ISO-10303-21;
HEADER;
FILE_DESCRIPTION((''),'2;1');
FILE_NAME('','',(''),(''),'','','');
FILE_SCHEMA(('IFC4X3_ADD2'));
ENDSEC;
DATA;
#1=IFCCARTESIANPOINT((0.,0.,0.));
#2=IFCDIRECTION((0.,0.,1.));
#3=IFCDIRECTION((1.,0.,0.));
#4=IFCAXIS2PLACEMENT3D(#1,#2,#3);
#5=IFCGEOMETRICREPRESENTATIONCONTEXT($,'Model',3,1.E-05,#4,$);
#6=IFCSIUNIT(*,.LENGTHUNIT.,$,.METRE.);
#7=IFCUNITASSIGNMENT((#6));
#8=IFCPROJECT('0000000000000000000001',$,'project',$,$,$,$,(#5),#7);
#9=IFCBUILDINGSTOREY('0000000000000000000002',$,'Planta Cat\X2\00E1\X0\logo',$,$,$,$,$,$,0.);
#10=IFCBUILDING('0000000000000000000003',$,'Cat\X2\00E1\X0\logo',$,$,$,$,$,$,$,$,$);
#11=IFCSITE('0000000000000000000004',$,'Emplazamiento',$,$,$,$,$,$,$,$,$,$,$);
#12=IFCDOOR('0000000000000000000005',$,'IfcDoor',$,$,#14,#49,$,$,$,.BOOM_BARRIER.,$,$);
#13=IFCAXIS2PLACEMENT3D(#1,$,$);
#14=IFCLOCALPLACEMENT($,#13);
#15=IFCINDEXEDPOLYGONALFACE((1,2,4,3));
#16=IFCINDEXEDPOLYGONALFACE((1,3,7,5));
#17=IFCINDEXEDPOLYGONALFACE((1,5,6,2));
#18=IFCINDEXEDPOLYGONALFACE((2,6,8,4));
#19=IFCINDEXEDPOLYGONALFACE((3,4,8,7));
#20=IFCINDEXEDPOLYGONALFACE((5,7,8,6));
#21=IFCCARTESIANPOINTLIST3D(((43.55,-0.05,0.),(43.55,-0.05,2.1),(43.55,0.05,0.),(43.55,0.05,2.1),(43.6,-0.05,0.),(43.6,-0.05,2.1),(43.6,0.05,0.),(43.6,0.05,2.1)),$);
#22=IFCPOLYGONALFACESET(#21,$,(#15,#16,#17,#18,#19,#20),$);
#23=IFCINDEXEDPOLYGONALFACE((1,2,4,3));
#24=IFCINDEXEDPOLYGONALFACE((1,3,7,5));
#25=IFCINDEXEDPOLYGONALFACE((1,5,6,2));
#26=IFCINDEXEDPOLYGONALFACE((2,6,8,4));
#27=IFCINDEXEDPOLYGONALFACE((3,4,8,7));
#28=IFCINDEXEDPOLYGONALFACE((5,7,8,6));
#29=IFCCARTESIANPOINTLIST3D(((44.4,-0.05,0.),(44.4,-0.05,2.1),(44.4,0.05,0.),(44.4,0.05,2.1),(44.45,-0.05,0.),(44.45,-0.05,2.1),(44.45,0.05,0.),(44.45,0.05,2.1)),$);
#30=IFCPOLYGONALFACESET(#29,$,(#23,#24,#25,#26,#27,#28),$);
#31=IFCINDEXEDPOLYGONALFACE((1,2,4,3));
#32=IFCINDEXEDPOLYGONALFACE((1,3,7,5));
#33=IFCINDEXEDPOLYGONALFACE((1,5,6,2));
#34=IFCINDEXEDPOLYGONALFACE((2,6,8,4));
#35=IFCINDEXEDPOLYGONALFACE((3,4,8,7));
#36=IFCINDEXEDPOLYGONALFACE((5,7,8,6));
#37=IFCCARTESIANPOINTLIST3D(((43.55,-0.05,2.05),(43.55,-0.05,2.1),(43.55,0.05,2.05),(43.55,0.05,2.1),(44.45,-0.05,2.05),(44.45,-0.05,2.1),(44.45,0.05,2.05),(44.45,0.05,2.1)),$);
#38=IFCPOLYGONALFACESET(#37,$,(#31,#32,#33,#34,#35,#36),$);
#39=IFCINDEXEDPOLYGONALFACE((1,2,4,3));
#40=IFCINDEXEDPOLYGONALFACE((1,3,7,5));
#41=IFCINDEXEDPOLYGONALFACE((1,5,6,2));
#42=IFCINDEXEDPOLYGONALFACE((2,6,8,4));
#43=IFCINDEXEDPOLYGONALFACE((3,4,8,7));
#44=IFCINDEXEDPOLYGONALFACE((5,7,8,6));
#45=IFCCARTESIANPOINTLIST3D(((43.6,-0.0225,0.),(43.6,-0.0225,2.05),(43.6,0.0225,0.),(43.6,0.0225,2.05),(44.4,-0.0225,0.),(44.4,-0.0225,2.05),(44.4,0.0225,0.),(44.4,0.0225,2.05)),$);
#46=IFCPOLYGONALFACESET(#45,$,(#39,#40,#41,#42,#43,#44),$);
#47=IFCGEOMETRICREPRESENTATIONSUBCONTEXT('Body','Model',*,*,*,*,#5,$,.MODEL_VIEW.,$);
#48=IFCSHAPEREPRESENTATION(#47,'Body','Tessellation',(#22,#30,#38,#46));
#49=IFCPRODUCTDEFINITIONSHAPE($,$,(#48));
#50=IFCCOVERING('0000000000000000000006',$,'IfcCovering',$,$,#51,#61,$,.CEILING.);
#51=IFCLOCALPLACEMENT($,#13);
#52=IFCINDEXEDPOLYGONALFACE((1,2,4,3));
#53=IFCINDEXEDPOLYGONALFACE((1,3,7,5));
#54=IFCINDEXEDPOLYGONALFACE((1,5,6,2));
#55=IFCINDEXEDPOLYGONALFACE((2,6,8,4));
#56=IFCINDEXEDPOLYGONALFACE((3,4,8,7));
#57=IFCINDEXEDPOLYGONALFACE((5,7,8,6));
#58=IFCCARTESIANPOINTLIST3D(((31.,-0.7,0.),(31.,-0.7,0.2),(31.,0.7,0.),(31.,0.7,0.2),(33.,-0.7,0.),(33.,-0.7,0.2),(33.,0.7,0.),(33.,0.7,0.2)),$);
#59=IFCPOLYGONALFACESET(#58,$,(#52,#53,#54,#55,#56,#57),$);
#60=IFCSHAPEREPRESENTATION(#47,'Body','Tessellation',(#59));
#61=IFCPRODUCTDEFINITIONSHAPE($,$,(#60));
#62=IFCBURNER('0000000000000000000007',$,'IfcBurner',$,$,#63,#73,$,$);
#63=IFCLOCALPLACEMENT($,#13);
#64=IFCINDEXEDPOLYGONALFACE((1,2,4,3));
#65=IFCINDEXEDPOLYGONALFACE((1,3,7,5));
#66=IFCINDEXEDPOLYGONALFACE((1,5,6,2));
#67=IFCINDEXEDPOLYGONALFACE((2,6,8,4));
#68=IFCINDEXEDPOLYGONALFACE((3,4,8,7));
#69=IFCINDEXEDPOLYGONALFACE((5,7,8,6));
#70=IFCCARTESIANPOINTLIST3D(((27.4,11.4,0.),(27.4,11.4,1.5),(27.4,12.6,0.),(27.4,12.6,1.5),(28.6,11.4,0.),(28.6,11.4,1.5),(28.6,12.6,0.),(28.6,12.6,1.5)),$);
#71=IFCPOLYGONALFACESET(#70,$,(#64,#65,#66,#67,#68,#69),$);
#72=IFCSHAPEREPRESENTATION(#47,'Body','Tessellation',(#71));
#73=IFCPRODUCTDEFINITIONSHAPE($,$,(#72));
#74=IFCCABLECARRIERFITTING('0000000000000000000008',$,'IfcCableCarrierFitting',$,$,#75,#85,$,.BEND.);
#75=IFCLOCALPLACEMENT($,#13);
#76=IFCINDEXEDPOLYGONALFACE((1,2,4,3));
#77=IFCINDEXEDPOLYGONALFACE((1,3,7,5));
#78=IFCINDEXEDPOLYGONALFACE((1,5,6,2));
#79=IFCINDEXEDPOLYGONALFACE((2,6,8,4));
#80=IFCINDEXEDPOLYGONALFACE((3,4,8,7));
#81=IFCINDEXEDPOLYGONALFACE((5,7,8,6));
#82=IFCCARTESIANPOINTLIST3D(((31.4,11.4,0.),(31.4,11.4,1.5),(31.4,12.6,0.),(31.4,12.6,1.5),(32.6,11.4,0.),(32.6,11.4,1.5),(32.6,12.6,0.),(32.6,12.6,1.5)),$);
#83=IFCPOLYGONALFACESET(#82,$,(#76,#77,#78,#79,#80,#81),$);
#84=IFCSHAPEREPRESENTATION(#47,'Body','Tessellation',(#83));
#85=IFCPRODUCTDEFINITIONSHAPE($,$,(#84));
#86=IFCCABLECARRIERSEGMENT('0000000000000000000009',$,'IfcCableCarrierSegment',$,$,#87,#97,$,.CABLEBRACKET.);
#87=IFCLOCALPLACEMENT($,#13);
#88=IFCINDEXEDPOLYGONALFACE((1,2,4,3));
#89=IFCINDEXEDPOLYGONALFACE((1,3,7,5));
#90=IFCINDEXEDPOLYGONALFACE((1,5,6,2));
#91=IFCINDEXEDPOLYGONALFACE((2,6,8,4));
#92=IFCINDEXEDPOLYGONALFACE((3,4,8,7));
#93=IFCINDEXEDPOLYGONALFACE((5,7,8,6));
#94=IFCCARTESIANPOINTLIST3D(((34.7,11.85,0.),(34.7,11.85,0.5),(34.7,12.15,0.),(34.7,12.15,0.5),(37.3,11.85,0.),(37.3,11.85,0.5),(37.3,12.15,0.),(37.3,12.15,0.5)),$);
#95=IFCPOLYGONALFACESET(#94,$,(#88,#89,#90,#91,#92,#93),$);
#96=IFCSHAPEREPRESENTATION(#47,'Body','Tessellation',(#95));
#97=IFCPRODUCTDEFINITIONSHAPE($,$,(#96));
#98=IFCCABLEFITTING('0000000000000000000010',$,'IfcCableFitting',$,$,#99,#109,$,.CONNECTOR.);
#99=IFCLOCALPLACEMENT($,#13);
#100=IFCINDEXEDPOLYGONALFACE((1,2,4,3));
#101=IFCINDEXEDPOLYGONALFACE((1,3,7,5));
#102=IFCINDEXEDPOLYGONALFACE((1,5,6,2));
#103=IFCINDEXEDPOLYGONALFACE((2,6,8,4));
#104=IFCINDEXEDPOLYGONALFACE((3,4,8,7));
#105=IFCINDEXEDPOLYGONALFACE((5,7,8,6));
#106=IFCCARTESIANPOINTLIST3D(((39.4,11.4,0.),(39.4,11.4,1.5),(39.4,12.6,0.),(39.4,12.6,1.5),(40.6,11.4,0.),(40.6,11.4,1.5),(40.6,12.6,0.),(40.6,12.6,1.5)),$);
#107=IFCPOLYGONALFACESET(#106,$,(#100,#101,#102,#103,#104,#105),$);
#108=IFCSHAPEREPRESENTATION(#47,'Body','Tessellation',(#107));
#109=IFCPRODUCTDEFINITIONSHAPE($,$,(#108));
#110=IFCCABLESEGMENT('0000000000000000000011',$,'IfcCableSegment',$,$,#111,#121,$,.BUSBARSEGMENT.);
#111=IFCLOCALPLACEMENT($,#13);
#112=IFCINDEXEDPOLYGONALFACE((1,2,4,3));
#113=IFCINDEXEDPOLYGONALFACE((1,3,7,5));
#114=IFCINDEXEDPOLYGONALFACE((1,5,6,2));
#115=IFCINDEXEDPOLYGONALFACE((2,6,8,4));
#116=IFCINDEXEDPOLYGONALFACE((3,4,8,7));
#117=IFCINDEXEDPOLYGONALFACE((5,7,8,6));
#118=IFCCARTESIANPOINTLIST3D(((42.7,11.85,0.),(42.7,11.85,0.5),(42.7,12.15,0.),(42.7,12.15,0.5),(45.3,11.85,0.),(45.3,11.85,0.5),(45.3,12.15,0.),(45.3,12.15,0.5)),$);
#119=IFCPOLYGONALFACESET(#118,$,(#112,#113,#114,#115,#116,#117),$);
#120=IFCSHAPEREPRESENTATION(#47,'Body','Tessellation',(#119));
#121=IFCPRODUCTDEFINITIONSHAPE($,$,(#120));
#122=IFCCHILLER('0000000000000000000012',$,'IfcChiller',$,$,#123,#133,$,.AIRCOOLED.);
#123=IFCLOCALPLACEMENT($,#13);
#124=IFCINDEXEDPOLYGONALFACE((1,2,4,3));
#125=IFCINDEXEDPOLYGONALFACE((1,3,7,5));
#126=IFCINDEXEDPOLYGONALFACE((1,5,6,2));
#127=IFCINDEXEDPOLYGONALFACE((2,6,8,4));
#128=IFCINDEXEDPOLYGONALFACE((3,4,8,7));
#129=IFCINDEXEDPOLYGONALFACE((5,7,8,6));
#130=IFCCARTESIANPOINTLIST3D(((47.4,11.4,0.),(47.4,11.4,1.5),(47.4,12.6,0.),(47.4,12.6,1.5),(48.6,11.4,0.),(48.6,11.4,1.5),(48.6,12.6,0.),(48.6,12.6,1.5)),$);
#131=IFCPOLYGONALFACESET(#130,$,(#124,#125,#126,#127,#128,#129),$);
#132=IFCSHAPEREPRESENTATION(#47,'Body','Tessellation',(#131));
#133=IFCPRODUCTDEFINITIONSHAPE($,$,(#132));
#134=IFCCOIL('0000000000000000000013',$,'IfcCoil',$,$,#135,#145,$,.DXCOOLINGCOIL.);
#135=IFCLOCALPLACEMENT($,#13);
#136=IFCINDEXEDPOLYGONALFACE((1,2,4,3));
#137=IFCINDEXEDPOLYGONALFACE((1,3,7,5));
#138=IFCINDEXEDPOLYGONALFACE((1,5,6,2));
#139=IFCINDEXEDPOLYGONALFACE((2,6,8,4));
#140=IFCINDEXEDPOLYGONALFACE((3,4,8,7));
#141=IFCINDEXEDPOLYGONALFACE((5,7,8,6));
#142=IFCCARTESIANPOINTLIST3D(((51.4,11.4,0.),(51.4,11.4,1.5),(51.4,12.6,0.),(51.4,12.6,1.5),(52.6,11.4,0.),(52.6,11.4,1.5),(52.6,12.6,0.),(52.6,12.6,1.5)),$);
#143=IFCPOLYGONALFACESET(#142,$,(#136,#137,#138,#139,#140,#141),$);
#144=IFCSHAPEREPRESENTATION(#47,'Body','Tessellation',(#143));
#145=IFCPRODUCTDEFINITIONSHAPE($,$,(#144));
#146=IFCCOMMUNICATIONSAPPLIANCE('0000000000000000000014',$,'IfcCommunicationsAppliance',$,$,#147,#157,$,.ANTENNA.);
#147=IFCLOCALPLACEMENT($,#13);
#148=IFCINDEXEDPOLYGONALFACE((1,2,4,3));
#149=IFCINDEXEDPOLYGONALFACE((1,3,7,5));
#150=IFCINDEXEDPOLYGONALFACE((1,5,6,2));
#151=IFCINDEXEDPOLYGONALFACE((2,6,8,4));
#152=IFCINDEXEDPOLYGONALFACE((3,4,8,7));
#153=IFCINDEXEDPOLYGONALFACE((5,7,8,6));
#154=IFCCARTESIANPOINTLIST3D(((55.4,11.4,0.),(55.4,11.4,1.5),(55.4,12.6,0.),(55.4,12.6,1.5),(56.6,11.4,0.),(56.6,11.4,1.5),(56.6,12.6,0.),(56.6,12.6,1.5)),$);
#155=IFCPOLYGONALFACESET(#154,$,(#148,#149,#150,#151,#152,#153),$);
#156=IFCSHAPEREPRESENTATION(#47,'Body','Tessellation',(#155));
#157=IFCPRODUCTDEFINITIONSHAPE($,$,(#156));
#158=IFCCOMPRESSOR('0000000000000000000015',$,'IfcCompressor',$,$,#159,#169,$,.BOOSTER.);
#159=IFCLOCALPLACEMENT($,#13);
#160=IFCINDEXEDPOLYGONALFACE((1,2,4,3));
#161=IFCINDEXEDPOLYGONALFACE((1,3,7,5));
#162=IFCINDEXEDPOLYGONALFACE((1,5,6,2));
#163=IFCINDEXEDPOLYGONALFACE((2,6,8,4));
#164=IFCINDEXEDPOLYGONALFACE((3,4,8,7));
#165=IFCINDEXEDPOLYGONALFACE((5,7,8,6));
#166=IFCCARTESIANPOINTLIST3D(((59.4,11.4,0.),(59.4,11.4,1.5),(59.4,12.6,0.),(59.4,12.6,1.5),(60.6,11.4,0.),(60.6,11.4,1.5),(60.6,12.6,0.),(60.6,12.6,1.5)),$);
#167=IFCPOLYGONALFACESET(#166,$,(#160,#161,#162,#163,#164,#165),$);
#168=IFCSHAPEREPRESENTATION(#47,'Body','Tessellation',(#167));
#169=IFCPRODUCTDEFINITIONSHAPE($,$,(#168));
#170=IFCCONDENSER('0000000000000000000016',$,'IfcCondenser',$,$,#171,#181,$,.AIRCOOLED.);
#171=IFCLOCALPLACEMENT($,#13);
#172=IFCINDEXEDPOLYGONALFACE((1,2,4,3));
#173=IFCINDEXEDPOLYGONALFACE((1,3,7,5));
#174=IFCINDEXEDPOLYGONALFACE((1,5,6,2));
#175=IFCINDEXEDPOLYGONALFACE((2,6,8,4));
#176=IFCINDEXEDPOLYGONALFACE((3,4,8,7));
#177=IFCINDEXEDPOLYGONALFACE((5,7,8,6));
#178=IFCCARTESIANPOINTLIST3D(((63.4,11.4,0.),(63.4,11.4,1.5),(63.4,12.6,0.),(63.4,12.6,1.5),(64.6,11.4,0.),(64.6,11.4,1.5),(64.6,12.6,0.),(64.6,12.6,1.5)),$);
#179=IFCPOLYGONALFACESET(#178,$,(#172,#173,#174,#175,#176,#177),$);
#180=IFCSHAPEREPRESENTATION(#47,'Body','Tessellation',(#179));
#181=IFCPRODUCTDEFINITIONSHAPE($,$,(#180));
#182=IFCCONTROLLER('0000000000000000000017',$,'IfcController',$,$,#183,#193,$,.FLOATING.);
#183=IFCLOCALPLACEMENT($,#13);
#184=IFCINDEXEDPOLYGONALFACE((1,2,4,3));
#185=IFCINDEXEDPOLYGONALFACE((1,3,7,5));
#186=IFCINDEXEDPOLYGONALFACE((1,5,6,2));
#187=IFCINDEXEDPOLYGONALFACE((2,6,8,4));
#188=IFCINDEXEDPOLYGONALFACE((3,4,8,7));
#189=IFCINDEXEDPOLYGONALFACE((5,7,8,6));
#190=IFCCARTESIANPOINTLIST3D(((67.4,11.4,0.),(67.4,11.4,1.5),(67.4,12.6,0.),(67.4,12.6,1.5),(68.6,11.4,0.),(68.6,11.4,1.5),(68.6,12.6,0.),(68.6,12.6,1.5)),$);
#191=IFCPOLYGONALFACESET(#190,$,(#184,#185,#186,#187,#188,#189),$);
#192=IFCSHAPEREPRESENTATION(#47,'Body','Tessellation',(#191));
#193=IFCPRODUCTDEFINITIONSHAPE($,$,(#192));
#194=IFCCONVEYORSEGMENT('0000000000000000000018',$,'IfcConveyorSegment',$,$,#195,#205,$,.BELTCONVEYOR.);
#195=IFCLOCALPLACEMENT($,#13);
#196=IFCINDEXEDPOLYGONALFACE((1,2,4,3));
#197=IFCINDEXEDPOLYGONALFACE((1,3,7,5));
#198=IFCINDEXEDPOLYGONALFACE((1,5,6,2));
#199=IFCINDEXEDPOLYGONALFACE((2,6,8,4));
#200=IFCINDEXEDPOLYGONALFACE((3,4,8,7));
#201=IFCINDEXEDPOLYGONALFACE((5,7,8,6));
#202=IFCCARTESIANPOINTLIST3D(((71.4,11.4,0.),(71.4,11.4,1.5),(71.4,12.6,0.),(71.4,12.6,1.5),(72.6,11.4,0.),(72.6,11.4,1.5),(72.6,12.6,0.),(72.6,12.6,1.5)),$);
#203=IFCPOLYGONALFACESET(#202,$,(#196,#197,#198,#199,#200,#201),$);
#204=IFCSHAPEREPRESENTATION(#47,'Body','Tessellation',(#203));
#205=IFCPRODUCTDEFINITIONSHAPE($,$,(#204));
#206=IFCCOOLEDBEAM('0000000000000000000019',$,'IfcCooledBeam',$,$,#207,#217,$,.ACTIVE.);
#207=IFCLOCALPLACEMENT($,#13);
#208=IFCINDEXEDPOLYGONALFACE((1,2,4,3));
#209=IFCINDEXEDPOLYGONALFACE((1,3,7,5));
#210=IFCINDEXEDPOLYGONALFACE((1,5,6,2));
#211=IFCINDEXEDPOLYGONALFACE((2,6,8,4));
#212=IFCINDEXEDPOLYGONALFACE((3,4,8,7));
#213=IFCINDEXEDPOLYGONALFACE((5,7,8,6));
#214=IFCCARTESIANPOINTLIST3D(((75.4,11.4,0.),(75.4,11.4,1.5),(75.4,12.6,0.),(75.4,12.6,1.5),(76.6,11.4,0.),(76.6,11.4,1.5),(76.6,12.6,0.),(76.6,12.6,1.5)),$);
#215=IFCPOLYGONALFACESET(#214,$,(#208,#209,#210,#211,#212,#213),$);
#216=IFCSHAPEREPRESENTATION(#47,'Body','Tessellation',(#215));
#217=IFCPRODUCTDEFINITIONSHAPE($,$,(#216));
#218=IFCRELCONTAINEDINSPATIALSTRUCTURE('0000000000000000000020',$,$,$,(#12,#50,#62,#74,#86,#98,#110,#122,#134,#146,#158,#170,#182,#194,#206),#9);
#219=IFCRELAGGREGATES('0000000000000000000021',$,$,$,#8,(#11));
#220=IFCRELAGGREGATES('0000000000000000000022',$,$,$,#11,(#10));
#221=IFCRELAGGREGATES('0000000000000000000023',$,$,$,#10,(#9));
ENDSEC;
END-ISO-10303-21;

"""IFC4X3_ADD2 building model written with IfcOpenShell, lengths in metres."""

from ifc_helpers import new_model, si_unit, frame, origin, origin_with_axes, origin_2d, place, context, subcontext, project, spatial, rectangle, extrude, element, save


model = new_model("IFC4X3_ADD2")

# Units and contexts
model_context = context("Model", 3, precision=1e-05, world=origin_with_axes())
body_context = subcontext(model_context, "Body", "Model", "MODEL_VIEW")
ifc_project = project(units=[si_unit("LENGTHUNIT", "METRE")], contexts=[model_context])

# Site, building, storey
site = spatial("IfcSite", under=ifc_project, Name="Emplazamiento")
building = spatial("IfcBuilding", under=site, Name="Catálogo")
storey = spatial("IfcBuildingStorey", under=building, Name="Planta Catálogo", Elevation=0.0)

# Door
door_placement = place(None, frame((44.0, 0.0, 0.0), z_axis=(0.0, 0.0, 1.0), x_axis=(1.0, 0.0, 0.0)))
element("IfcDoor", 1, at=door_placement, inside=storey, Name="IfcDoor", PredefinedType="BOOM_BARRIER", context=body_context, shape_type="SweptSolid", body=[
    extrude(rectangle(XDim=0.05, YDim=0.1, at=origin_2d()), frame((-0.425, 0.0, 0.0)), (0.0, 0.0, 1.0), 2.1),
    extrude(rectangle(XDim=0.05, YDim=0.1, at=origin_2d()), frame((0.425, 0.0, 0.0)), (0.0, 0.0, 1.0), 2.1),
    extrude(rectangle(XDim=0.9, YDim=0.1, at=origin_2d()), frame((0.0, 0.0, 2.05)), (0.0, 0.0, 1.0), 0.05),
    extrude(rectangle(XDim=0.8, YDim=0.045, at=origin_2d()), origin(), (0.0, 0.0, 1.0), 2.05),
])

# Covering
covering_placement = place(None, frame((32.0, 0.0, 0.0), z_axis=(0.0, 0.0, 1.0), x_axis=(1.0, 0.0, 0.0)))
element("IfcCovering", 2, at=covering_placement, inside=storey, Name="IfcCovering", PredefinedType="CEILING", context=body_context, shape_type="SweptSolid", body=[
    extrude(rectangle(XDim=2.0, YDim=1.4, at=origin_2d()), origin(), (0.0, 0.0, 1.0), 0.2),
])

# Burner
burner_placement = place(None, frame((28.0, 12.0, 0.0), z_axis=(0.0, 0.0, 1.0), x_axis=(1.0, 0.0, 0.0)))
element("IfcBurner", 3, at=burner_placement, inside=storey, Name="IfcBurner", context=body_context, shape_type="SweptSolid", body=[
    extrude(rectangle(XDim=1.2, YDim=1.2, at=origin_2d()), origin(), (0.0, 0.0, 1.0), 1.5),
])

# Cable carrier fitting
cable_carrier_fitting_placement = place(None, frame((32.0, 12.0, 0.0), z_axis=(0.0, 0.0, 1.0), x_axis=(1.0, 0.0, 0.0)))
element("IfcCableCarrierFitting", 4, at=cable_carrier_fitting_placement, inside=storey, Name="IfcCableCarrierFitting", PredefinedType="BEND", context=body_context, shape_type="SweptSolid", body=[
    extrude(rectangle(XDim=1.2, YDim=1.2, at=origin_2d()), origin(), (0.0, 0.0, 1.0), 1.5),
])

# Cable carrier segment
cable_carrier_segment_placement = place(None, frame((36.0, 12.0, 0.0), z_axis=(0.0, 0.0, 1.0), x_axis=(1.0, 0.0, 0.0)))
element("IfcCableCarrierSegment", 5, at=cable_carrier_segment_placement, inside=storey, Name="IfcCableCarrierSegment", PredefinedType="CABLEBRACKET", context=body_context, shape_type="SweptSolid", body=[
    extrude(rectangle(XDim=2.6, YDim=0.3, at=origin_2d()), origin(), (0.0, 0.0, 1.0), 0.5),
])

# Cable fitting
cable_fitting_placement = place(None, frame((40.0, 12.0, 0.0), z_axis=(0.0, 0.0, 1.0), x_axis=(1.0, 0.0, 0.0)))
element("IfcCableFitting", 6, at=cable_fitting_placement, inside=storey, Name="IfcCableFitting", PredefinedType="CONNECTOR", context=body_context, shape_type="SweptSolid", body=[
    extrude(rectangle(XDim=1.2, YDim=1.2, at=origin_2d()), origin(), (0.0, 0.0, 1.0), 1.5),
])

# Cable segment
cable_segment_placement = place(None, frame((44.0, 12.0, 0.0), z_axis=(0.0, 0.0, 1.0), x_axis=(1.0, 0.0, 0.0)))
element("IfcCableSegment", 7, at=cable_segment_placement, inside=storey, Name="IfcCableSegment", PredefinedType="BUSBARSEGMENT", context=body_context, shape_type="SweptSolid", body=[
    extrude(rectangle(XDim=2.6, YDim=0.3, at=origin_2d()), origin(), (0.0, 0.0, 1.0), 0.5),
])

# Chiller
chiller_placement = place(None, frame((48.0, 12.0, 0.0), z_axis=(0.0, 0.0, 1.0), x_axis=(1.0, 0.0, 0.0)))
element("IfcChiller", 8, at=chiller_placement, inside=storey, Name="IfcChiller", PredefinedType="AIRCOOLED", context=body_context, shape_type="SweptSolid", body=[
    extrude(rectangle(XDim=1.2, YDim=1.2, at=origin_2d()), origin(), (0.0, 0.0, 1.0), 1.5),
])

# Coil
coil_placement = place(None, frame((52.0, 12.0, 0.0), z_axis=(0.0, 0.0, 1.0), x_axis=(1.0, 0.0, 0.0)))
element("IfcCoil", 9, at=coil_placement, inside=storey, Name="IfcCoil", PredefinedType="DXCOOLINGCOIL", context=body_context, shape_type="SweptSolid", body=[
    extrude(rectangle(XDim=1.2, YDim=1.2, at=origin_2d()), origin(), (0.0, 0.0, 1.0), 1.5),
])

# Communications appliance
communications_appliance_placement = place(None, frame((56.0, 12.0, 0.0), z_axis=(0.0, 0.0, 1.0), x_axis=(1.0, 0.0, 0.0)))
element("IfcCommunicationsAppliance", 10, at=communications_appliance_placement, inside=storey, Name="IfcCommunicationsAppliance", PredefinedType="ANTENNA", context=body_context, shape_type="SweptSolid", body=[
    extrude(rectangle(XDim=1.2, YDim=1.2, at=origin_2d()), origin(), (0.0, 0.0, 1.0), 1.5),
])

# Compressor
compressor_placement = place(None, frame((60.0, 12.0, 0.0), z_axis=(0.0, 0.0, 1.0), x_axis=(1.0, 0.0, 0.0)))
element("IfcCompressor", 11, at=compressor_placement, inside=storey, Name="IfcCompressor", PredefinedType="BOOSTER", context=body_context, shape_type="SweptSolid", body=[
    extrude(rectangle(XDim=1.2, YDim=1.2, at=origin_2d()), origin(), (0.0, 0.0, 1.0), 1.5),
])

# Condenser
condenser_placement = place(None, frame((64.0, 12.0, 0.0), z_axis=(0.0, 0.0, 1.0), x_axis=(1.0, 0.0, 0.0)))
element("IfcCondenser", 12, at=condenser_placement, inside=storey, Name="IfcCondenser", PredefinedType="AIRCOOLED", context=body_context, shape_type="SweptSolid", body=[
    extrude(rectangle(XDim=1.2, YDim=1.2, at=origin_2d()), origin(), (0.0, 0.0, 1.0), 1.5),
])

# Controller
controller_placement = place(None, frame((68.0, 12.0, 0.0), z_axis=(0.0, 0.0, 1.0), x_axis=(1.0, 0.0, 0.0)))
element("IfcController", 13, at=controller_placement, inside=storey, Name="IfcController", PredefinedType="FLOATING", context=body_context, shape_type="SweptSolid", body=[
    extrude(rectangle(XDim=1.2, YDim=1.2, at=origin_2d()), origin(), (0.0, 0.0, 1.0), 1.5),
])

# Conveyor segment
conveyor_segment_placement = place(None, frame((72.0, 12.0, 0.0), z_axis=(0.0, 0.0, 1.0), x_axis=(1.0, 0.0, 0.0)))
element("IfcConveyorSegment", 14, at=conveyor_segment_placement, inside=storey, Name="IfcConveyorSegment", PredefinedType="BELTCONVEYOR", context=body_context, shape_type="SweptSolid", body=[
    extrude(rectangle(XDim=1.2, YDim=1.2, at=origin_2d()), origin(), (0.0, 0.0, 1.0), 1.5),
])

# Cooled beam
cooled_beam_placement = place(None, frame((76.0, 12.0, 0.0), z_axis=(0.0, 0.0, 1.0), x_axis=(1.0, 0.0, 0.0)))
element("IfcCooledBeam", 15, at=cooled_beam_placement, inside=storey, Name="IfcCooledBeam", PredefinedType="ACTIVE", context=body_context, shape_type="SweptSolid", body=[
    extrude(rectangle(XDim=1.2, YDim=1.2, at=origin_2d()), origin(), (0.0, 0.0, 1.0), 1.5),
])

save(model, "model.ifc")
